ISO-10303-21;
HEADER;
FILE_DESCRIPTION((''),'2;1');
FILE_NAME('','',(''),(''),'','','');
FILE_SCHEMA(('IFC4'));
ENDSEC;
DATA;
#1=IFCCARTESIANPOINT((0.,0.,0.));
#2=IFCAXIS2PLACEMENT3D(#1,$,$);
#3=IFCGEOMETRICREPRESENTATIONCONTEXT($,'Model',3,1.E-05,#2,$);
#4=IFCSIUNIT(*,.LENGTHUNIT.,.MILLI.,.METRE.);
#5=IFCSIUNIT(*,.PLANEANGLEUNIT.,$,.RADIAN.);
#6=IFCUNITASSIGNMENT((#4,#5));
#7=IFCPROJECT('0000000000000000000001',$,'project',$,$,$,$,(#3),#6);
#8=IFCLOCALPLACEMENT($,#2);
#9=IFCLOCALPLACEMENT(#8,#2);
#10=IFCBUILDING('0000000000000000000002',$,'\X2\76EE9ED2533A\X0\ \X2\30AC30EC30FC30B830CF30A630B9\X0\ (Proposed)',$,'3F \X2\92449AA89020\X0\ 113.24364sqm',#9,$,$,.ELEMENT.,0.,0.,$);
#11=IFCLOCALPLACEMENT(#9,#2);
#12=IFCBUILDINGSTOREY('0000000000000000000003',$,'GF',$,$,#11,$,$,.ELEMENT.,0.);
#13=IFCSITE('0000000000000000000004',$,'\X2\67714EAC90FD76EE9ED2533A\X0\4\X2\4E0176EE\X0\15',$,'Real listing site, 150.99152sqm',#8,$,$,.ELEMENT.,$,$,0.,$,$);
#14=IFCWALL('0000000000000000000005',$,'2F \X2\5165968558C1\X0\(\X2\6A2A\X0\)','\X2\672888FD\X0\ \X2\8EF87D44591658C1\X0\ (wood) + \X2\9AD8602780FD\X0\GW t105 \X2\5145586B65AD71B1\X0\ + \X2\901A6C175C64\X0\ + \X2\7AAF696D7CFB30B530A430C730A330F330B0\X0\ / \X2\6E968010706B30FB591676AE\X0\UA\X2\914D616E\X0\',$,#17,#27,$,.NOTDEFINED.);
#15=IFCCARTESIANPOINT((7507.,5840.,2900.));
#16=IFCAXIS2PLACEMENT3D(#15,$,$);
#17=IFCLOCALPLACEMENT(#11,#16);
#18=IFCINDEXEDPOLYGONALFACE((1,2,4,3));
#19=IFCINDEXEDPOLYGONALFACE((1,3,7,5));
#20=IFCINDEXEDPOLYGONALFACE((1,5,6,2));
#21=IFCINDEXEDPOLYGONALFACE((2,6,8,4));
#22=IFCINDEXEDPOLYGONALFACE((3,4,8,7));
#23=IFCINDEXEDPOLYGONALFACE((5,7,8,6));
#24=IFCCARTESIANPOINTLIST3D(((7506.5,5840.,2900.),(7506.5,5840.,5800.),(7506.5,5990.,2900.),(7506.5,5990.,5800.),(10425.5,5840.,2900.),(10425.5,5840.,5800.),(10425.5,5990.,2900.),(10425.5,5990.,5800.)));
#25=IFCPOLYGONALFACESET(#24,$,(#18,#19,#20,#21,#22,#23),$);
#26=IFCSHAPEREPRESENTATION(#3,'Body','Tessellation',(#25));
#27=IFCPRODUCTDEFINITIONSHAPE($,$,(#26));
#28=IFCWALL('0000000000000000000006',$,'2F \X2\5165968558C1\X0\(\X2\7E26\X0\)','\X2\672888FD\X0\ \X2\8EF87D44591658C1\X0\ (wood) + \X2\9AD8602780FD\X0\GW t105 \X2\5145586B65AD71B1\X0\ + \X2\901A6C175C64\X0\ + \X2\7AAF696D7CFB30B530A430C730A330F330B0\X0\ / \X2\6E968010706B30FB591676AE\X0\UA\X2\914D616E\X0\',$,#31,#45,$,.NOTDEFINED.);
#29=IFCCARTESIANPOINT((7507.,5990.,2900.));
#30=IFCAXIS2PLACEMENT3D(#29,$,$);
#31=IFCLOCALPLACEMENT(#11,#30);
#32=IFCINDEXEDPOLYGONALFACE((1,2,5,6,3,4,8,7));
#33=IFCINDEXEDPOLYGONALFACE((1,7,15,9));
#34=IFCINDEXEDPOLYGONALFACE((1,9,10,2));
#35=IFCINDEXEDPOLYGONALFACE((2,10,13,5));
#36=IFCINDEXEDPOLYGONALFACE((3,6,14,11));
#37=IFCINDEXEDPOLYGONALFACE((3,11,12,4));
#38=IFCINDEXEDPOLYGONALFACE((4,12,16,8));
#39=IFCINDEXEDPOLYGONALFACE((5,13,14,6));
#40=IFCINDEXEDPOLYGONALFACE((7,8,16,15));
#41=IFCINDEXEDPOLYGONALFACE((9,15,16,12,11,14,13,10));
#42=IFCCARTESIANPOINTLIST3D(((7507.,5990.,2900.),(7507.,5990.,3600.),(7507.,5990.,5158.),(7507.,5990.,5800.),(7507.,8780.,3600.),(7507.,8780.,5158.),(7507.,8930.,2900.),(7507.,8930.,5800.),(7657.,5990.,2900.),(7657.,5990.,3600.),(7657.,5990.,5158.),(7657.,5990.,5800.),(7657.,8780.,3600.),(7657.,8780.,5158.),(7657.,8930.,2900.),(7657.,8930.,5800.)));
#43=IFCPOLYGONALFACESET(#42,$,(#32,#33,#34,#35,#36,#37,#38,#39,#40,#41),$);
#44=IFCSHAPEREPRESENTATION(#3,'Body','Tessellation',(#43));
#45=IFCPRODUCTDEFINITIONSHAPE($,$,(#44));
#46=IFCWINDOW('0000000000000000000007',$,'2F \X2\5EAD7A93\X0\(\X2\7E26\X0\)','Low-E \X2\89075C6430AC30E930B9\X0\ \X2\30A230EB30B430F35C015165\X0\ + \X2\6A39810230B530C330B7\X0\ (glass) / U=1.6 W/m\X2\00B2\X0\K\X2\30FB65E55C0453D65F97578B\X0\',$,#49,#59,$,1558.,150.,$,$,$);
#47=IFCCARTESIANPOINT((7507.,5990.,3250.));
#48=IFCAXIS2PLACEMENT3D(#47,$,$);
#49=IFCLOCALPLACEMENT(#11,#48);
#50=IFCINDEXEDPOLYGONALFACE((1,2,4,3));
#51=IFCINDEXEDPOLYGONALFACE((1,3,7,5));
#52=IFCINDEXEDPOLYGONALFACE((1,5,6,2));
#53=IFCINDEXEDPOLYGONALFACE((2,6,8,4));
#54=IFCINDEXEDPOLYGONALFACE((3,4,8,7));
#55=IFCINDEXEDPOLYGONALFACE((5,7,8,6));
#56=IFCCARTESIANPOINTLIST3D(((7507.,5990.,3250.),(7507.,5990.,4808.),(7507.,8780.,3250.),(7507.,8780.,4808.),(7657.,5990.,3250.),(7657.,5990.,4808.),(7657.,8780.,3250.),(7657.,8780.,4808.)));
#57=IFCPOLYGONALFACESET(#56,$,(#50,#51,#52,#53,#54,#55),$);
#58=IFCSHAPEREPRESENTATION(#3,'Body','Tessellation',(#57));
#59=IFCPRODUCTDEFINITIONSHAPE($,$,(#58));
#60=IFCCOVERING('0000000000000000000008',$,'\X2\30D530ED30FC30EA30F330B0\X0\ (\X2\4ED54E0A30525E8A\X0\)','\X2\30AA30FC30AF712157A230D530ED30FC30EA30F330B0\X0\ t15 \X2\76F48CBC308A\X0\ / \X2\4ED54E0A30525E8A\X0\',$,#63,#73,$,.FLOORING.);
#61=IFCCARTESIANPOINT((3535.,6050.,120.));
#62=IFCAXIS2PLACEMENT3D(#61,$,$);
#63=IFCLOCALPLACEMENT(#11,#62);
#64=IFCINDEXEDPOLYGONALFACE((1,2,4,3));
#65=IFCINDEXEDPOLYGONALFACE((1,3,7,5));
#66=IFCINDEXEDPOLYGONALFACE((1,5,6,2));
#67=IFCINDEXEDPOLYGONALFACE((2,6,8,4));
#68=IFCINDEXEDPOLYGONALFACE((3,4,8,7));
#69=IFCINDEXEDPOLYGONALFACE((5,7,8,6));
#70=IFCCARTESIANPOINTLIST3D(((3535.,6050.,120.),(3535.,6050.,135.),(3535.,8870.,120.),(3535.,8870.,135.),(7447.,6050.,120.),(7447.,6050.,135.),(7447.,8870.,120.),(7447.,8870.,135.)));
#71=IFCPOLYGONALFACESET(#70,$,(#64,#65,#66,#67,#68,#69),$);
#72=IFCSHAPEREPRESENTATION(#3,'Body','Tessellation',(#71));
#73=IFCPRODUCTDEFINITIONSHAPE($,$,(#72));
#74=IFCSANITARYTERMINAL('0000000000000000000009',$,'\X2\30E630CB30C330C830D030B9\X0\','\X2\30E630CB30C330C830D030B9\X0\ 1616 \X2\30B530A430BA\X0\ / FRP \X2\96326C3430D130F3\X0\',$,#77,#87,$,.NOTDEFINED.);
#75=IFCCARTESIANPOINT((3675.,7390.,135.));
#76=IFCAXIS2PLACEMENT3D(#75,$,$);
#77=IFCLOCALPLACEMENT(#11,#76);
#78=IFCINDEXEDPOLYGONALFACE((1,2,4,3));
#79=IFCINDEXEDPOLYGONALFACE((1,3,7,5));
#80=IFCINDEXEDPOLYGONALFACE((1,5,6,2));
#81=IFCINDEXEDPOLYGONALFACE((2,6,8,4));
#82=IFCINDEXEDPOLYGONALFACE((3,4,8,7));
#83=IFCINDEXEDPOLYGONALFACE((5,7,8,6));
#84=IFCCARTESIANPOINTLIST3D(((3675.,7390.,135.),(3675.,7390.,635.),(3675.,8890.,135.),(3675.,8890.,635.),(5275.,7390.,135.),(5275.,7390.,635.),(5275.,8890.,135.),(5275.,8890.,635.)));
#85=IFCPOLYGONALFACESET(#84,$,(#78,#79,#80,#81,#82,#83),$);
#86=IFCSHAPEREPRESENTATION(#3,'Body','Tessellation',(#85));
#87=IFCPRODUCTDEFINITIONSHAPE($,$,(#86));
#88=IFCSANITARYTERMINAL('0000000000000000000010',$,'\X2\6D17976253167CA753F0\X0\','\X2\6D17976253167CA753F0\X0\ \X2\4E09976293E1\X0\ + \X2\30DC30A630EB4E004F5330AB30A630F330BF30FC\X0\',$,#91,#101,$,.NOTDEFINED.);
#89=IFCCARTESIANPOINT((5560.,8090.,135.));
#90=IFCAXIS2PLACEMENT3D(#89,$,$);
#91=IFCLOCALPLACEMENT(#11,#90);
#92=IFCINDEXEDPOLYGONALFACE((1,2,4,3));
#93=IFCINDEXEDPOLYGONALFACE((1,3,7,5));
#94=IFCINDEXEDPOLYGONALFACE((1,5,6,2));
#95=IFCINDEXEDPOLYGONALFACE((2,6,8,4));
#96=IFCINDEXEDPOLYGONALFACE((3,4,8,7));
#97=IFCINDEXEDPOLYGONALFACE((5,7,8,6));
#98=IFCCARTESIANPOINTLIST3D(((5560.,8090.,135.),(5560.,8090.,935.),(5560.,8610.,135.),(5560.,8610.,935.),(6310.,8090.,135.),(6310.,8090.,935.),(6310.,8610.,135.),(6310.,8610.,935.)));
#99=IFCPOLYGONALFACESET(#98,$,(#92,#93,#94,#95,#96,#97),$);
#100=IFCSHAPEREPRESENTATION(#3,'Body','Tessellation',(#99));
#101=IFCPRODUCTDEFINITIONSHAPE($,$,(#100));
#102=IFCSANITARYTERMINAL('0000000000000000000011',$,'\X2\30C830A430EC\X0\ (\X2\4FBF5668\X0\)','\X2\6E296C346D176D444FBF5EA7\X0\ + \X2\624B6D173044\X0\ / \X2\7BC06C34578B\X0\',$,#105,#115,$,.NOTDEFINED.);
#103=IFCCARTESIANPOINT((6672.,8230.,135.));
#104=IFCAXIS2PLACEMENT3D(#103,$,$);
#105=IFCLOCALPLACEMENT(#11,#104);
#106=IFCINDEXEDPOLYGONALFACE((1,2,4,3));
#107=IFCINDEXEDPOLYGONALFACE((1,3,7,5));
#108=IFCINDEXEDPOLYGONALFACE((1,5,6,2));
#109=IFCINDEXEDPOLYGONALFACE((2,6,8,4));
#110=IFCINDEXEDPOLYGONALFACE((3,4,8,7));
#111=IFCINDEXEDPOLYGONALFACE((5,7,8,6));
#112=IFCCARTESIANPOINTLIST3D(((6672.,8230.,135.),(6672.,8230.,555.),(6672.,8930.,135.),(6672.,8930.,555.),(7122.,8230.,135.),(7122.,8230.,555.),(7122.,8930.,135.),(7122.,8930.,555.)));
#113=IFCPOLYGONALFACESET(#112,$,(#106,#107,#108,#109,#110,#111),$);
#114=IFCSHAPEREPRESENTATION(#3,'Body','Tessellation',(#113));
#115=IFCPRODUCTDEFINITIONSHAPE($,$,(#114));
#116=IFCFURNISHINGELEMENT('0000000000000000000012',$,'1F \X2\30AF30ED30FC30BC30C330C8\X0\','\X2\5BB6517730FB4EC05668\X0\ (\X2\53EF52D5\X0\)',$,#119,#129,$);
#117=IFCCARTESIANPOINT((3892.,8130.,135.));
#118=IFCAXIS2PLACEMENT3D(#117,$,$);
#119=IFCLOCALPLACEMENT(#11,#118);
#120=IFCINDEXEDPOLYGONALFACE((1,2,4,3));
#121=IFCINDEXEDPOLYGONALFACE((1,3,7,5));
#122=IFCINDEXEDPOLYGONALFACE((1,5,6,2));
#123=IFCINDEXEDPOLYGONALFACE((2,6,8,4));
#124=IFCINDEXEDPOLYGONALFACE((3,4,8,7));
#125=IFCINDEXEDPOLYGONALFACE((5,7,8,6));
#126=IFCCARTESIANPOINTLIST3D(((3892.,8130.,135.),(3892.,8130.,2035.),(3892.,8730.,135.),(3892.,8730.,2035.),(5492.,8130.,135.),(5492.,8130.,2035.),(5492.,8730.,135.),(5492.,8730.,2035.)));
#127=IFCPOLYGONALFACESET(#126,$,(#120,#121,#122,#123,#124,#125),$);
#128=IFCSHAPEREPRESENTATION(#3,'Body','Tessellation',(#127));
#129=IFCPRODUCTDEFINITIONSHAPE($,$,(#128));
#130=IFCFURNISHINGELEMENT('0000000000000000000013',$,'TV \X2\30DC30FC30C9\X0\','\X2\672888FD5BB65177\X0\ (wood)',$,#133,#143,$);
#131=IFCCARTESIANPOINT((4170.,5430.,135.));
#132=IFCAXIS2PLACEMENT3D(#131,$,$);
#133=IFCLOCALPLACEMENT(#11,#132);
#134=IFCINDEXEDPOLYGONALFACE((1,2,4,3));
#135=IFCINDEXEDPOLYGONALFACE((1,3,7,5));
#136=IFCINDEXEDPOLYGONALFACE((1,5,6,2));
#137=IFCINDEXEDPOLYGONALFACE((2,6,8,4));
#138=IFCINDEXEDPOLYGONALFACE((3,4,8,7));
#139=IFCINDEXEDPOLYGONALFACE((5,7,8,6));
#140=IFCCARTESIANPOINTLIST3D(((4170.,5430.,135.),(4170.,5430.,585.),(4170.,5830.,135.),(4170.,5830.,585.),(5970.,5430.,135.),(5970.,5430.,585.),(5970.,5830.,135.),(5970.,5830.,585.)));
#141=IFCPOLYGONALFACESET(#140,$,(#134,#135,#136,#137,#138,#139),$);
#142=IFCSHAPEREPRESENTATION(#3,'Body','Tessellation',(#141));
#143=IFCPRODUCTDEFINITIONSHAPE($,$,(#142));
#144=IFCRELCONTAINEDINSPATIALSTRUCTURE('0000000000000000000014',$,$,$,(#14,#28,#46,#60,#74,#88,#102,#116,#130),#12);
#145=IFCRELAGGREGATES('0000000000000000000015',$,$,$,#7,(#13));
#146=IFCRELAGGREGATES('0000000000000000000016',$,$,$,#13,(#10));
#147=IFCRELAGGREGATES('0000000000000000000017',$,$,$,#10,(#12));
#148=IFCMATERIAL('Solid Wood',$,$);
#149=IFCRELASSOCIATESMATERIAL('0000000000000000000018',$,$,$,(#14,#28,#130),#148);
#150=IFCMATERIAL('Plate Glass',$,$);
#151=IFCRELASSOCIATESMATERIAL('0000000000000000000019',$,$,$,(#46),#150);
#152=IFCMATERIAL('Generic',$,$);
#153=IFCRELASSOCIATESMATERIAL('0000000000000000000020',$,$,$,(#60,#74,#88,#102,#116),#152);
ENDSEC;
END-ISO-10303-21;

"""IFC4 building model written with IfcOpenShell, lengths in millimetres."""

from ifc_helpers import new_model, si_unit, frame, frame_2d, origin, place, context, project, spatial, rectangle, extrude, material, element, fill, save


model = new_model("IFC4")

# Units and contexts
model_context = context("Model", 3, precision=1e-05, world=origin())
ifc_project = project(units=[si_unit("LENGTHUNIT", "METRE", prefix="MILLI"), si_unit("PLANEANGLEUNIT", "RADIAN")], contexts=[model_context])

# Site, building, storey
site_placement = place(None, origin())
site = spatial("IfcSite", under=ifc_project, at=site_placement, Name="東京都目黒区4丁目15", ObjectType="Real listing site, 150.99152sqm", CompositionType="ELEMENT", RefElevation=0.0)
building_placement = place(site_placement, origin())
building = spatial("IfcBuilding", under=site, at=building_placement, Name="目黒区 ガレージハウス (Proposed)", ObjectType="3F 鉄骨造 113.24364sqm", CompositionType="ELEMENT", ElevationOfRefHeight=0.0, ElevationOfTerrain=0.0)
storey_placement = place(building_placement, origin())
storey = spatial("IfcBuildingStorey", under=building, at=storey_placement, Name="GF", CompositionType="ELEMENT", Elevation=0.0)

# Shared definitions
ifc_material_1 = material(Name="Solid Wood")

# Shared definitions
ifc_material_2 = material(Name="Plate Glass")

# Wall
wall_1_placement = place(storey_placement, frame((7507.0, 5840.0, 2900.0)))
element("IfcWall", 1, at=wall_1_placement, inside=storey, material=ifc_material_1, Name="2F 入隅壁(横)", Description="木製 軸組外壁 (wood) + 高性能GW t105 充填断熱 + 通気層 + 窯業系サイディング / 準耐火・外皮UA配慮", PredefinedType="NOTDEFINED", context=model_context, shape_type="SweptSolid", body=[
    extrude(rectangle(XDim=2919.0, YDim=150.0, at=frame_2d((1459.0, 75.0))), frame((7507.0, 5840.0, 2900.0)), (0.0, 0.0, 1.0), 2900.0),
])

# Wall, opening, window
wall_2_placement = place(storey_placement, frame((7507.0, 5990.0, 2900.0)))
wall_2 = element("IfcWall", 2, at=wall_2_placement, inside=storey, material=ifc_material_1, Name="2F 入隅壁(縦)", Description="木製 軸組外壁 (wood) + 高性能GW t105 充填断熱 + 通気層 + 窯業系サイディング / 準耐火・外皮UA配慮", PredefinedType="NOTDEFINED", context=model_context, shape_type="SweptSolid", body=[
    extrude(rectangle(XDim=150.0, YDim=2940.0, at=frame_2d((75.0, 1470.0))), frame((7507.0, 5990.0, 2900.0)), (0.0, 0.0, 1.0), 2900.0),
])
opening_1_placement = place(storey_placement, frame((7507.0, 5990.0, 3250.0)))
opening_1 = element("IfcOpeningElement", 3, at=opening_1_placement, cuts=wall_2, PredefinedType="NOTDEFINED", context=model_context, shape_type="SweptSolid", body=[
    extrude(rectangle(XDim=150.0, YDim=2790.0, at=frame_2d((75.0, 1395.0))), frame((7507.0, 5990.0, 3250.0)), (0.0, 0.0, 1.0), 1558.0),
])
window_1_placement = place(storey_placement, frame((7507.0, 5990.0, 3250.0)))
window_1 = element("IfcWindow", 4, at=window_1_placement, inside=storey, material=ifc_material_2, Name="2F 庭窓(縦)", Description="Low-E 複層ガラス アルゴン封入 + 樹脂サッシ (glass) / U=1.6 W/m²K・日射取得型", OverallHeight=1558.0, OverallWidth=150.0, context=model_context, shape_type="SweptSolid", body=[
    extrude(rectangle(XDim=150.0, YDim=2790.0, at=frame_2d((75.0, 1395.0))), frame((7507.0, 5990.0, 3250.0)), (0.0, 0.0, 1.0), 1558.0),
])
fill(opening_1, window_1)

# Covering
ifc_material_3 = material(Name="Generic")
covering_placement = place(storey_placement, frame((3535.0, 6050.0, 120.0)))
element("IfcCovering", 5, at=covering_placement, inside=storey, material=ifc_material_3, Name="フローリング (仕上げ床)", Description="オーク無垢フローリング t15 直貼り / 仕上げ床", PredefinedType="FLOORING", context=model_context, shape_type="SweptSolid", body=[
    extrude(rectangle(XDim=3912.0, YDim=2820.0, at=frame_2d((1956.0, 1410.0))), frame((3535.0, 6050.0, 120.0)), (0.0, 0.0, 1.0), 15.0),
])

# Sanitary terminals
sanitary_terminal_1_placement = place(storey_placement, frame((3675.0, 7390.0, 135.0)))
element("IfcSanitaryTerminal", 6, at=sanitary_terminal_1_placement, inside=storey, material=ifc_material_3, Name="ユニットバス", Description="ユニットバス 1616 サイズ / FRP 防水パン", PredefinedType="NOTDEFINED", context=model_context, shape_type="SweptSolid", body=[
    extrude(rectangle(XDim=1600.0, YDim=1500.0, at=frame_2d((800.0, 750.0))), frame((3675.0, 7390.0, 135.0)), (0.0, 0.0, 1.0), 500.0),
])
sanitary_terminal_2_placement = place(storey_placement, frame((5560.0, 8090.0, 135.0)))
element("IfcSanitaryTerminal", 7, at=sanitary_terminal_2_placement, inside=storey, material=ifc_material_3, Name="洗面化粧台", Description="洗面化粧台 三面鏡 + ボウル一体カウンター", PredefinedType="NOTDEFINED", context=model_context, shape_type="SweptSolid", body=[
    extrude(rectangle(XDim=750.0, YDim=520.0, at=frame_2d((375.0, 260.0))), frame((5560.0, 8090.0, 135.0)), (0.0, 0.0, 1.0), 800.0),
])
sanitary_terminal_3_placement = place(storey_placement, frame((6672.0, 8230.0, 135.0)))
element("IfcSanitaryTerminal", 8, at=sanitary_terminal_3_placement, inside=storey, material=ifc_material_3, Name="トイレ (便器)", Description="温水洗浄便座 + 手洗い / 節水型", PredefinedType="NOTDEFINED", context=model_context, shape_type="SweptSolid", body=[
    extrude(rectangle(XDim=450.0, YDim=700.0, at=frame_2d((225.0, 350.0))), frame((6672.0, 8230.0, 135.0)), (0.0, 0.0, 1.0), 420.0),
])

# Furnishing elements
furnishing_1_placement = place(storey_placement, frame((3892.0, 8130.0, 135.0)))
element("IfcFurnishingElement", 9, at=furnishing_1_placement, inside=storey, material=ifc_material_3, Name="1F クローゼット", Description="家具・什器 (可動)", context=model_context, shape_type="SweptSolid", body=[
    extrude(rectangle(XDim=1600.0, YDim=600.0, at=frame_2d((800.0, 300.0))), frame((3892.0, 8130.0, 135.0)), (0.0, 0.0, 1.0), 1900.0),
])
furnishing_2_placement = place(storey_placement, frame((4170.0, 5430.0, 135.0)))
element("IfcFurnishingElement", 10, at=furnishing_2_placement, inside=storey, material=ifc_material_1, Name="TV ボード", Description="木製家具 (wood)", context=model_context, shape_type="SweptSolid", body=[
    extrude(rectangle(XDim=1800.0, YDim=400.0, at=frame_2d((900.0, 200.0))), frame((4170.0, 5430.0, 135.0)), (0.0, 0.0, 1.0), 450.0),
])

save(model, "model.ifc")
